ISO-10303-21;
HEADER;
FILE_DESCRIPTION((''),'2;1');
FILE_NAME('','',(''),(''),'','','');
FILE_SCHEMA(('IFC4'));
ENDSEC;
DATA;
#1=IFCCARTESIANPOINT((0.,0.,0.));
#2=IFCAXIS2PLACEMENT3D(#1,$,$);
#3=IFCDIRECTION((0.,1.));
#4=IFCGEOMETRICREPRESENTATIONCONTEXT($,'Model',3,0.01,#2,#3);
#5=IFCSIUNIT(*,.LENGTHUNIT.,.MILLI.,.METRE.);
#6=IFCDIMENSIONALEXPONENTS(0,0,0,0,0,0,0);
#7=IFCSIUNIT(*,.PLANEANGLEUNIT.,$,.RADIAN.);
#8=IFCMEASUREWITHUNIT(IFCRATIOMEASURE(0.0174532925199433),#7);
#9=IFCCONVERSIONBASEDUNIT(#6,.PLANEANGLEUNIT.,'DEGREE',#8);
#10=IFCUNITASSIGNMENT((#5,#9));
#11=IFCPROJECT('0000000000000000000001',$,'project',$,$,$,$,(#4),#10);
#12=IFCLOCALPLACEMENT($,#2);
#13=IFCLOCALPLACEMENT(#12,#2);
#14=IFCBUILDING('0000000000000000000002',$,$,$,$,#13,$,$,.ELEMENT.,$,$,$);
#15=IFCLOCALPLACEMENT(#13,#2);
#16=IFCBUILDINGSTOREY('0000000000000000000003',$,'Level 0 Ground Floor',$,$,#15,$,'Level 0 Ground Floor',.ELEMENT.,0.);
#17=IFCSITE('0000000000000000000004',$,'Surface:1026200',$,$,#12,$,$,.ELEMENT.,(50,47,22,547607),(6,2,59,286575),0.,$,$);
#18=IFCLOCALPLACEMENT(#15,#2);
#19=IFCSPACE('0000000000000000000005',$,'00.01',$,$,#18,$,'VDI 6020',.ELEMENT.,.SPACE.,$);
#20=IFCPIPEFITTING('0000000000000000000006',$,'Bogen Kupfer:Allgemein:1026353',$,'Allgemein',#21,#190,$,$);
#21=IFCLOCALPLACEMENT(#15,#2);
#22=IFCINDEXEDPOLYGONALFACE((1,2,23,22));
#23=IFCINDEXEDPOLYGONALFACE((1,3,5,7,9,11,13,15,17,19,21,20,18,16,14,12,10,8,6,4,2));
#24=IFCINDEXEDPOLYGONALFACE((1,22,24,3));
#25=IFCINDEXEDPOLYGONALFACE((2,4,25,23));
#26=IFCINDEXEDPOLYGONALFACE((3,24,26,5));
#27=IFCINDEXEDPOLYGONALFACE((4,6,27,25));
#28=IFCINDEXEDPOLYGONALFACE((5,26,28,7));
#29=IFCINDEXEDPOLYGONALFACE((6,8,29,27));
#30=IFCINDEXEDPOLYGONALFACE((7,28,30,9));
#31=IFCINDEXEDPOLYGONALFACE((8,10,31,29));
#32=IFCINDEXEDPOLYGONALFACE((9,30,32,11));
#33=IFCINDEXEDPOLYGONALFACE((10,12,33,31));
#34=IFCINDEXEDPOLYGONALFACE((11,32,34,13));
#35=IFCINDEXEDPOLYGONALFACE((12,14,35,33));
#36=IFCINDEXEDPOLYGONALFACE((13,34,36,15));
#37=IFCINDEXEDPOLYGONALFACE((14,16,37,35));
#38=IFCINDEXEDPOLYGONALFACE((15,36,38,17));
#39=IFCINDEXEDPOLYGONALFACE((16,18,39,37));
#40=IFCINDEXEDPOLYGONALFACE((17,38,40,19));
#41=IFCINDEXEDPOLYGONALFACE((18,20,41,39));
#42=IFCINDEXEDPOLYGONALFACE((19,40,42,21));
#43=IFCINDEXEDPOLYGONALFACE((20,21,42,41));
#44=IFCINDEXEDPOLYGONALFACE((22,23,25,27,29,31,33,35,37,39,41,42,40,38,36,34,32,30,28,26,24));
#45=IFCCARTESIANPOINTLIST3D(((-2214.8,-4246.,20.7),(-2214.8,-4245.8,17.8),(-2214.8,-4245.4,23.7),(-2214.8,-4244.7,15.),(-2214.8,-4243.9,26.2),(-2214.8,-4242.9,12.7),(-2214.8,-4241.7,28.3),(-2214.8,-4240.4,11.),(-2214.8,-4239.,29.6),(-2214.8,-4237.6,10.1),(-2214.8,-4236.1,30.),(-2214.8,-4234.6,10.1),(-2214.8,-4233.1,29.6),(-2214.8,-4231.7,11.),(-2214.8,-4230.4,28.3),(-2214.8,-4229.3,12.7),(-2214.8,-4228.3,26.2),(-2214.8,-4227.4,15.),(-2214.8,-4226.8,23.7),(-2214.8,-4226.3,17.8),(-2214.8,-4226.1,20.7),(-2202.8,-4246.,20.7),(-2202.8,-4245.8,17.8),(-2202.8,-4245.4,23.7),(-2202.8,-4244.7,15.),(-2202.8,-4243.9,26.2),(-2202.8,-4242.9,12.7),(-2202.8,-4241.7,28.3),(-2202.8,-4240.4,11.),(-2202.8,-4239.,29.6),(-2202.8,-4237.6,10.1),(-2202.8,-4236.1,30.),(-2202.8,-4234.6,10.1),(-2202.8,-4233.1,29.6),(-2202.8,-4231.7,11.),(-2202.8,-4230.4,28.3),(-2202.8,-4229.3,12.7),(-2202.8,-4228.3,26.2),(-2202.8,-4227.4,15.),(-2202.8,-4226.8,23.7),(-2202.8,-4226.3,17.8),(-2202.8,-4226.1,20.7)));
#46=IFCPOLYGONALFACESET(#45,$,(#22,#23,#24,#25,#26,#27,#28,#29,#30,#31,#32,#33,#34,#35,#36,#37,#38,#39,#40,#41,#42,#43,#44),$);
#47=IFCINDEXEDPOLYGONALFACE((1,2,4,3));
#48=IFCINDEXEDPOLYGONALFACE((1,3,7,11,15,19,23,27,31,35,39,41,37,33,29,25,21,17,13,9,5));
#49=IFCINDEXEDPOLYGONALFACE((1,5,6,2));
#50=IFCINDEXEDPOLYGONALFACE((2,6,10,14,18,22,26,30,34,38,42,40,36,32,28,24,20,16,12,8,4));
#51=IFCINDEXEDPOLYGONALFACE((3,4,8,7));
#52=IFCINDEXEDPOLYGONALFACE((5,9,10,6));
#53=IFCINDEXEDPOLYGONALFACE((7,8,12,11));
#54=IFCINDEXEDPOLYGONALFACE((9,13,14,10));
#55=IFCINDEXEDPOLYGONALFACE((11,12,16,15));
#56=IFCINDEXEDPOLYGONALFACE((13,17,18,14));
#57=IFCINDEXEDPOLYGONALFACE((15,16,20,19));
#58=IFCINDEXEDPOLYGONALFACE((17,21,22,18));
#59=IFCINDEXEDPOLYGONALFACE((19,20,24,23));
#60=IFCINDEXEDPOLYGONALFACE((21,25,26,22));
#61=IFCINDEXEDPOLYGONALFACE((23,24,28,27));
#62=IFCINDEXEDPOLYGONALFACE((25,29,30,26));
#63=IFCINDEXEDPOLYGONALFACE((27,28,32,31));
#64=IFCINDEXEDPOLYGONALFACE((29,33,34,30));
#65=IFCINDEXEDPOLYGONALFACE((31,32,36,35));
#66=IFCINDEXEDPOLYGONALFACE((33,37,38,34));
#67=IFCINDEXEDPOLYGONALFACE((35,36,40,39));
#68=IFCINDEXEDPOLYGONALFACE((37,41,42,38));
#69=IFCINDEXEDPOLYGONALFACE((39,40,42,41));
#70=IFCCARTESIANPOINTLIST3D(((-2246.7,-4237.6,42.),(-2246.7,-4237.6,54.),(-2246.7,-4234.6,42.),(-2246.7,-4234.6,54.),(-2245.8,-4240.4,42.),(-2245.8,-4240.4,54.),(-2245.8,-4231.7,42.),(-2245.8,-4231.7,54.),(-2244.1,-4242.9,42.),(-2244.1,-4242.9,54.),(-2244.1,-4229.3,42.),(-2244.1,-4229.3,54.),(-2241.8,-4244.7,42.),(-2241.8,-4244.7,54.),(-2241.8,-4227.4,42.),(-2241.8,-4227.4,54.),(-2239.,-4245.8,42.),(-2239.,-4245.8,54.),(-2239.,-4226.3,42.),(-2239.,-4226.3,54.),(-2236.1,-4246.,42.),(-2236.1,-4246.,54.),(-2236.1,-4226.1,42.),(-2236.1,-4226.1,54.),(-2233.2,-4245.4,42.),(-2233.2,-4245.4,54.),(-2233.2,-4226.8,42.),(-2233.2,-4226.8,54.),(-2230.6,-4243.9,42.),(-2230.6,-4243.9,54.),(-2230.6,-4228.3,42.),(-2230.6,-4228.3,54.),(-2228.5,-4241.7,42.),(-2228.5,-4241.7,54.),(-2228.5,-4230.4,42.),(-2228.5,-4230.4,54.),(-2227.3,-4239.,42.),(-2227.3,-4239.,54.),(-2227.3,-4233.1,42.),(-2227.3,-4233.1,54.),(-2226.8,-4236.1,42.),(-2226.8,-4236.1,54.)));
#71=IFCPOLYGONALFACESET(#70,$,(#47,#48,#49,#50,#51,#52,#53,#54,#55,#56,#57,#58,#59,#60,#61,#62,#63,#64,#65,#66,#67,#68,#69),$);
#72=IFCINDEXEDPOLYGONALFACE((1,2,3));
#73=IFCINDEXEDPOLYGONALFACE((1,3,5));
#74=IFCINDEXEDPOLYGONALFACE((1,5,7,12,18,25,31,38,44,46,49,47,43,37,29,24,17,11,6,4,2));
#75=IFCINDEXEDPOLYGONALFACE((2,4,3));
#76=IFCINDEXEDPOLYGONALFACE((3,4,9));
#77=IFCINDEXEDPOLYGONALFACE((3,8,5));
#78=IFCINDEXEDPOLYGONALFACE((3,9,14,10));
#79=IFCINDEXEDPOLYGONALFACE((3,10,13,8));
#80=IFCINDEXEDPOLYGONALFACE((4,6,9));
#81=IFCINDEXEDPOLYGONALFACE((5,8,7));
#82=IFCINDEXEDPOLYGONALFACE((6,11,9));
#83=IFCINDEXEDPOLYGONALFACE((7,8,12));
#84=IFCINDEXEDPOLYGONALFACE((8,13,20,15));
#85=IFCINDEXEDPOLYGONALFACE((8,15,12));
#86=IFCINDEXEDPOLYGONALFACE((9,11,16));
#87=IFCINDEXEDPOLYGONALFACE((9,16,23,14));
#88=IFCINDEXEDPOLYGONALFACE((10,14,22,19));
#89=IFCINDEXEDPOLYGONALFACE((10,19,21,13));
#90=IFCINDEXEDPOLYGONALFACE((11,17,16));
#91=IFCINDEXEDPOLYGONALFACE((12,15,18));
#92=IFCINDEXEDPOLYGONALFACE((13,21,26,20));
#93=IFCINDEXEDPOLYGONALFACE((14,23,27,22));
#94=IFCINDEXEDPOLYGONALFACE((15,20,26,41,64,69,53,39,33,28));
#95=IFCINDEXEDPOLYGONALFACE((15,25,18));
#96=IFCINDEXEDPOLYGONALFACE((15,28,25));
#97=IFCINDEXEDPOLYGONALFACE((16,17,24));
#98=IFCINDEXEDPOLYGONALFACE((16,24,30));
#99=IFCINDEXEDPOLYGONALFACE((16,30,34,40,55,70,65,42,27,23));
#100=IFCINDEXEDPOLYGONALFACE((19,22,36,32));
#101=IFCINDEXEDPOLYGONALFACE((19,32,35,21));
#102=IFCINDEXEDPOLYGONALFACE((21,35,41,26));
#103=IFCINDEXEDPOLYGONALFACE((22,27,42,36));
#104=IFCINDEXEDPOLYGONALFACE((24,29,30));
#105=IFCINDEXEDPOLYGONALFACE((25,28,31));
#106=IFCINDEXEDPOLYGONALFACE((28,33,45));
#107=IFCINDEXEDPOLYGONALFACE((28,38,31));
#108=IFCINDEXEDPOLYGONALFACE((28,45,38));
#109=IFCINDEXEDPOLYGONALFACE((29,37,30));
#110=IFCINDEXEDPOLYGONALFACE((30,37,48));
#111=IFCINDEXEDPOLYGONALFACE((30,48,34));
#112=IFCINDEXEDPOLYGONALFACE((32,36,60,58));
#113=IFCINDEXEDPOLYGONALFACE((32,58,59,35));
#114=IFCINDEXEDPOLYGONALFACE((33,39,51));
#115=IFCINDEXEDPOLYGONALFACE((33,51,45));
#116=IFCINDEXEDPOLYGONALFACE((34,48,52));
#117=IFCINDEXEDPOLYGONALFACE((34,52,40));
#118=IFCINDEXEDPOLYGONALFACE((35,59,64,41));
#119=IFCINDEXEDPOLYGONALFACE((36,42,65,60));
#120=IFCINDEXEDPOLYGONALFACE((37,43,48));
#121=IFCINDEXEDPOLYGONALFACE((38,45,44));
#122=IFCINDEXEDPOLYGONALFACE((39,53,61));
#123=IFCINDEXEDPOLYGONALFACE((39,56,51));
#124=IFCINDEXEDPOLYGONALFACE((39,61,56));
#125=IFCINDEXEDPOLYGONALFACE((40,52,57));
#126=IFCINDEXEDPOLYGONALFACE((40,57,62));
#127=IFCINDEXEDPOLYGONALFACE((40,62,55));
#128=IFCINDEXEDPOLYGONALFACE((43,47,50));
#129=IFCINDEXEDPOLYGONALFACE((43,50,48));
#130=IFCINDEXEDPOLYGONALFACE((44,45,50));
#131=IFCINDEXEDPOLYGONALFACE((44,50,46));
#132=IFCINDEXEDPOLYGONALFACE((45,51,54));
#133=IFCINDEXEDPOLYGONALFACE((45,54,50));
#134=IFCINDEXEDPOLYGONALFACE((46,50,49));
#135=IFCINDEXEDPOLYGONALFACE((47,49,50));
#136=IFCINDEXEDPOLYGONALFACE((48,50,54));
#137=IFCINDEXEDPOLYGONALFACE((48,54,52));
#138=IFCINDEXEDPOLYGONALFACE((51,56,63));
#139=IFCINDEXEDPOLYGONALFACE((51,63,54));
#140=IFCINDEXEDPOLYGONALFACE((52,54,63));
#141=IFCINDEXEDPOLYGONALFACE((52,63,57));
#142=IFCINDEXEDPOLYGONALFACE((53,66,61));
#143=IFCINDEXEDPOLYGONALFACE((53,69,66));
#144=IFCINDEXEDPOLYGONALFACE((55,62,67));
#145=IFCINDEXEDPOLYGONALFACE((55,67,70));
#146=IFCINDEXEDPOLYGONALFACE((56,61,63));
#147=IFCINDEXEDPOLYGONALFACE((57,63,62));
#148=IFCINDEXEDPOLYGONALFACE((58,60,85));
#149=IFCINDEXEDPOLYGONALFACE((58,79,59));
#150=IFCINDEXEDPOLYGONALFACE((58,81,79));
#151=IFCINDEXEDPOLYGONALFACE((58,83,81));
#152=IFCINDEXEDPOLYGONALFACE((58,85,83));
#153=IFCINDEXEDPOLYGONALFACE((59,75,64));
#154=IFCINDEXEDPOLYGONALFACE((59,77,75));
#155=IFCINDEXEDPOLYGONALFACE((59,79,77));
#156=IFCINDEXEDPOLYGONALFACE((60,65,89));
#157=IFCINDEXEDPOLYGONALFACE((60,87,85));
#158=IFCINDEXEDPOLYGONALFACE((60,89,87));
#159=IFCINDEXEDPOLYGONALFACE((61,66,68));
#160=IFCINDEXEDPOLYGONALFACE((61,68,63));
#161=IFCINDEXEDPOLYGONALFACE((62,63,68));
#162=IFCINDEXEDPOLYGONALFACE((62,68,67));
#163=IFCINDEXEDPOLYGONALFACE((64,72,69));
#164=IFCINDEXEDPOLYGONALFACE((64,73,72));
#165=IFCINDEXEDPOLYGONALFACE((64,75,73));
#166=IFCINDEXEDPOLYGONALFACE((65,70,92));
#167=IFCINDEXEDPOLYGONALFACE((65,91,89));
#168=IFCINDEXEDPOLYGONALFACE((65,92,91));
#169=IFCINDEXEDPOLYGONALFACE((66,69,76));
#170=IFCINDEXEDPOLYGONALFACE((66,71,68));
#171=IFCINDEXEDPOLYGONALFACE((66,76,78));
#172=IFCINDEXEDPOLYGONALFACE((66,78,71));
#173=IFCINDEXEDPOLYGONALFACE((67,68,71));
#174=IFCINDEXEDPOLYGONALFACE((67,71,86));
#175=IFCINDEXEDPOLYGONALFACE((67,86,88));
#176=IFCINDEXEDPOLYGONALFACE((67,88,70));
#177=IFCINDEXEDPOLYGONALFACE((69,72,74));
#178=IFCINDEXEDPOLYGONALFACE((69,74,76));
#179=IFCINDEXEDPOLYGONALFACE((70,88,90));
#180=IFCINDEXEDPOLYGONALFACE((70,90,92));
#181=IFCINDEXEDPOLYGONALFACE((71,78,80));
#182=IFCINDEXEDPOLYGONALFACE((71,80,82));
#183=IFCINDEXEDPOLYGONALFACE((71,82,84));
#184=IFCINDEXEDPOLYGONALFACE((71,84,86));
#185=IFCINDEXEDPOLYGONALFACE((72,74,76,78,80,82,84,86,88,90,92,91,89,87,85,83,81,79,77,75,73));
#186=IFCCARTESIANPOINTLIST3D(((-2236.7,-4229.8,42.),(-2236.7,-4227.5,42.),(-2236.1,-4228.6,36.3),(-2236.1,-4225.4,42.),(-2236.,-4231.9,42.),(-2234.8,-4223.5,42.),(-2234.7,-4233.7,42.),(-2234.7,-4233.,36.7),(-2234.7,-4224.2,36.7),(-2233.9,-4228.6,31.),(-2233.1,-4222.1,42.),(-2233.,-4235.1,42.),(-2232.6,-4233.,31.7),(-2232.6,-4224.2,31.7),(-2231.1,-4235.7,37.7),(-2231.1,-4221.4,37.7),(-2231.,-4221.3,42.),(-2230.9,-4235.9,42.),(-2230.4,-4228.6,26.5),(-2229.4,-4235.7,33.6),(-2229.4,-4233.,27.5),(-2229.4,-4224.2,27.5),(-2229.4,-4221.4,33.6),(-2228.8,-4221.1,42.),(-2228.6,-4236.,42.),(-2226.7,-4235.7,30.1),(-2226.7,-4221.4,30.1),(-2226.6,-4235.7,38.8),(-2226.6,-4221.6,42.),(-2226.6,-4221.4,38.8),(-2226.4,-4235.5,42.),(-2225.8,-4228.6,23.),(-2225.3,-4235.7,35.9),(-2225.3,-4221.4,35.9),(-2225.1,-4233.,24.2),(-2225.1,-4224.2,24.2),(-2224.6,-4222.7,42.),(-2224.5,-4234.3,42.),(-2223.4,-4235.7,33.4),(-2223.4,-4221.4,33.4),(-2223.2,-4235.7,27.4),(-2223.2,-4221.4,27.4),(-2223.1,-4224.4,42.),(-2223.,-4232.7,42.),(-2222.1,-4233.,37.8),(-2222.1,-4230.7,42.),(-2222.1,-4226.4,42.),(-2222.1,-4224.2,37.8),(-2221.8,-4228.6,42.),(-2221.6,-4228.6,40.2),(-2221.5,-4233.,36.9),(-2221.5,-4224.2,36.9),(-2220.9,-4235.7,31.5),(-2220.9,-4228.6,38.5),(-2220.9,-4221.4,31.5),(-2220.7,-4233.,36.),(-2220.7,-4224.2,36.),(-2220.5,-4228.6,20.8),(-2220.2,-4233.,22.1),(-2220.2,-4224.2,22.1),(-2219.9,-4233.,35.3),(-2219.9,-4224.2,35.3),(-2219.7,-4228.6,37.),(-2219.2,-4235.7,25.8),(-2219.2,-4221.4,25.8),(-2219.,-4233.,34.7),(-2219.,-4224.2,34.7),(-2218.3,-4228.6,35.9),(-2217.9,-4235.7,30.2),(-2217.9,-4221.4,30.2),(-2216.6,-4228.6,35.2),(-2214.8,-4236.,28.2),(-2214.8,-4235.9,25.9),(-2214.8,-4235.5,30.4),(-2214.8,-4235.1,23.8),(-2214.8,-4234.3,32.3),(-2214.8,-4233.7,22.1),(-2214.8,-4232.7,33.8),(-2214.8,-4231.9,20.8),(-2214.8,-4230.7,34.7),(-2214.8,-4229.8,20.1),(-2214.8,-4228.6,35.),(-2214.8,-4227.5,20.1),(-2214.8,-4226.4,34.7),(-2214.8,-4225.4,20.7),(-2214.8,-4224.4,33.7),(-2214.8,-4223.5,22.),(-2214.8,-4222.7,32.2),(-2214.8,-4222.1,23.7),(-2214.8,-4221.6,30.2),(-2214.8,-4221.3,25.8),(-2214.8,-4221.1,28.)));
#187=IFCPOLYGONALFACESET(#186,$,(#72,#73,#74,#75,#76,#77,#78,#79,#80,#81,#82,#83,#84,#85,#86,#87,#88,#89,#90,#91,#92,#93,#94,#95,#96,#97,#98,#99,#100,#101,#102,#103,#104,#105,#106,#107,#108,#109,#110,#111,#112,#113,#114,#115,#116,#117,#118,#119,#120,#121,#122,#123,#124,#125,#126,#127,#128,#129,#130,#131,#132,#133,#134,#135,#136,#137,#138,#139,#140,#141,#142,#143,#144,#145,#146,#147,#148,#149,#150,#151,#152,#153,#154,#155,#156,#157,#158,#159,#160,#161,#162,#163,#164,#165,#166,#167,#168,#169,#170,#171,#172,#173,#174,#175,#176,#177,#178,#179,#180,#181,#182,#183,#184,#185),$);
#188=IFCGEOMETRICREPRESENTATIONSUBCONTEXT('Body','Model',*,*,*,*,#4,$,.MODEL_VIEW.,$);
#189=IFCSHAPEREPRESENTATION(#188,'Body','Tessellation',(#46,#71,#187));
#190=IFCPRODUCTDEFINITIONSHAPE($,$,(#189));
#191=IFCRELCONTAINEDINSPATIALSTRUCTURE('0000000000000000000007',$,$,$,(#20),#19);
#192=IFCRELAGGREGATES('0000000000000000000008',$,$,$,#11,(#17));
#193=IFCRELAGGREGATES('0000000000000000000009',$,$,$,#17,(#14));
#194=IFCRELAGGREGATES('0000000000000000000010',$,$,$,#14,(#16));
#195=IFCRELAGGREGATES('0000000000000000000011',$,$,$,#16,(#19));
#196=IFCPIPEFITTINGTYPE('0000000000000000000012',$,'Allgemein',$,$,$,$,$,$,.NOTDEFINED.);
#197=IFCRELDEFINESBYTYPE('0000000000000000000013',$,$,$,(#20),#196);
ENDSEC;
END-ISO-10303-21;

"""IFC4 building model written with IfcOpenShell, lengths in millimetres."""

from ifc_helpers import new_model, entity, si_unit, converted_unit, direction, frame, frame_2d, origin, place, context, subcontext, project, spatial, circle, extrude, source, transform, mapped, type_object, type_shapes, element, save


model = new_model("IFC4")

# Units and contexts
model_context = context("Model", 3, precision=0.01, world=origin(), true_north=direction((0.0, 1.0)))
body_context = subcontext(model_context, "Body", "Model", "MODEL_VIEW")
ifc_project = project(units=[si_unit("LENGTHUNIT", "METRE", prefix="MILLI"), converted_unit("PLANEANGLEUNIT", "DEGREE", entity("IfcRatioMeasure", 0.0174532925199433), si_unit("PLANEANGLEUNIT", "RADIAN"), dimensions=[0, 0, 0, 0, 0, 0, 0])], contexts=[model_context])

# Site, building, storey
site_placement = place(None, origin())
site = spatial("IfcSite", under=ifc_project, at=site_placement, Name="Surface:1026200", CompositionType="ELEMENT", RefLatitude=(50, 47, 22, 547607), RefLongitude=(6, 2, 59, 286575), RefElevation=0.0)
building_placement = place(site_placement, origin())
building = spatial("IfcBuilding", under=site, at=building_placement, CompositionType="ELEMENT")
storey_placement = place(building_placement, origin())
storey = spatial("IfcBuildingStorey", under=building, at=storey_placement, Name="Level 0 Ground Floor", LongName="Level 0 Ground Floor", CompositionType="ELEMENT", Elevation=0.0)

# Shared definitions
pipe_fitting_type = type_object("IfcPipeFittingType", Name="Allgemein", PredefinedType="NOTDEFINED")
ifc_direction = entity("IfcDirection", [0.0, 0.0, -1.0])
trimmed_curve = entity("IfcTrimmedCurve", entity("IfcCircle", entity("IfcAxis2Placement2D", entity("IfcCartesianPoint", [-14.5, 0.0]), entity("IfcDirection", [0.0, 1.0])), 14.5), [entity("IfcParameterValue", 270.0)], [entity("IfcParameterValue", 0.0)], True, "PARAMETER")
shared_shape_1 = source(origin(), body_context, "Body", "SolidModel", [
    extrude(circle(Radius=10.0, at=frame_2d((0.0, 0.0), x_axis=(1.0, 0.0))), frame((0.0, 22.0, 0.0), z_axis=(0.0, 1.0, 0.0), x_axis=(-1.0, 0.0, 0.0)), (0.0, 0.0, 1.0), 12.0),
    extrude(circle(Radius=10.0, at=frame_2d((0.0, 0.0), x_axis=(1.0, 0.0))), frame((-34.0, 0.0, 0.0), z_axis=(1.0, 0.0, 0.0), x_axis=(0.0, 1.0, 0.0)), (0.0, 0.0, 1.0), 12.0),
    entity("IfcSurfaceCurveSweptAreaSolid", entity("IfcCircleProfileDef", "AREA", None, entity("IfcAxis2Placement2D", entity("IfcCartesianPoint", [0.0, 7.5]), entity("IfcDirection", [1.0, 0.0])), 7.5), entity("IfcAxis2Placement3D", entity("IfcCartesianPoint", [-7.5, 22.0, 0.0]), ifc_direction, entity("IfcDirection", [1.0, 0.0, 0.0])), trimmed_curve, 0.0, 90.0, entity("IfcSurfaceOfLinearExtrusion", entity("IfcArbitraryOpenProfileDef", "CURVE", None, trimmed_curve), entity("IfcAxis2Placement3D", entity("IfcCartesianPoint", [0.0, 0.0, -304.8])), ifc_direction, 1.0)),
])
type_shapes(pipe_fitting_type, [shared_shape_1])

# Shared definitions
space_placement = place(storey_placement, origin())
space = spatial("IfcSpace", under=storey, at=space_placement, Name="00.01", LongName="VDI 6020", CompositionType="ELEMENT", PredefinedType="SPACE")

# Pipe fitting
for number, where, z_axis, x_axis, name in (
    (1, (-2236.8, -4236.1, 20.0), (0.0, -1.0, 0.0), (0.0, 0.0, -1.0), "Bogen Kupfer:Allgemein:1026353"),
):
    element("IfcPipeFitting", number, at=place(space_placement, frame(where, z_axis=z_axis, x_axis=x_axis)), inside=space, type_object=pipe_fitting_type, Name=name, ObjectType="Allgemein", context=body_context, shape_type="MappedRepresentation", body=[
        mapped(shared_shape_1, transform((0.0, 0.0, 0.0), scale=1.0)),
    ])

save(model, "model.ifc")
